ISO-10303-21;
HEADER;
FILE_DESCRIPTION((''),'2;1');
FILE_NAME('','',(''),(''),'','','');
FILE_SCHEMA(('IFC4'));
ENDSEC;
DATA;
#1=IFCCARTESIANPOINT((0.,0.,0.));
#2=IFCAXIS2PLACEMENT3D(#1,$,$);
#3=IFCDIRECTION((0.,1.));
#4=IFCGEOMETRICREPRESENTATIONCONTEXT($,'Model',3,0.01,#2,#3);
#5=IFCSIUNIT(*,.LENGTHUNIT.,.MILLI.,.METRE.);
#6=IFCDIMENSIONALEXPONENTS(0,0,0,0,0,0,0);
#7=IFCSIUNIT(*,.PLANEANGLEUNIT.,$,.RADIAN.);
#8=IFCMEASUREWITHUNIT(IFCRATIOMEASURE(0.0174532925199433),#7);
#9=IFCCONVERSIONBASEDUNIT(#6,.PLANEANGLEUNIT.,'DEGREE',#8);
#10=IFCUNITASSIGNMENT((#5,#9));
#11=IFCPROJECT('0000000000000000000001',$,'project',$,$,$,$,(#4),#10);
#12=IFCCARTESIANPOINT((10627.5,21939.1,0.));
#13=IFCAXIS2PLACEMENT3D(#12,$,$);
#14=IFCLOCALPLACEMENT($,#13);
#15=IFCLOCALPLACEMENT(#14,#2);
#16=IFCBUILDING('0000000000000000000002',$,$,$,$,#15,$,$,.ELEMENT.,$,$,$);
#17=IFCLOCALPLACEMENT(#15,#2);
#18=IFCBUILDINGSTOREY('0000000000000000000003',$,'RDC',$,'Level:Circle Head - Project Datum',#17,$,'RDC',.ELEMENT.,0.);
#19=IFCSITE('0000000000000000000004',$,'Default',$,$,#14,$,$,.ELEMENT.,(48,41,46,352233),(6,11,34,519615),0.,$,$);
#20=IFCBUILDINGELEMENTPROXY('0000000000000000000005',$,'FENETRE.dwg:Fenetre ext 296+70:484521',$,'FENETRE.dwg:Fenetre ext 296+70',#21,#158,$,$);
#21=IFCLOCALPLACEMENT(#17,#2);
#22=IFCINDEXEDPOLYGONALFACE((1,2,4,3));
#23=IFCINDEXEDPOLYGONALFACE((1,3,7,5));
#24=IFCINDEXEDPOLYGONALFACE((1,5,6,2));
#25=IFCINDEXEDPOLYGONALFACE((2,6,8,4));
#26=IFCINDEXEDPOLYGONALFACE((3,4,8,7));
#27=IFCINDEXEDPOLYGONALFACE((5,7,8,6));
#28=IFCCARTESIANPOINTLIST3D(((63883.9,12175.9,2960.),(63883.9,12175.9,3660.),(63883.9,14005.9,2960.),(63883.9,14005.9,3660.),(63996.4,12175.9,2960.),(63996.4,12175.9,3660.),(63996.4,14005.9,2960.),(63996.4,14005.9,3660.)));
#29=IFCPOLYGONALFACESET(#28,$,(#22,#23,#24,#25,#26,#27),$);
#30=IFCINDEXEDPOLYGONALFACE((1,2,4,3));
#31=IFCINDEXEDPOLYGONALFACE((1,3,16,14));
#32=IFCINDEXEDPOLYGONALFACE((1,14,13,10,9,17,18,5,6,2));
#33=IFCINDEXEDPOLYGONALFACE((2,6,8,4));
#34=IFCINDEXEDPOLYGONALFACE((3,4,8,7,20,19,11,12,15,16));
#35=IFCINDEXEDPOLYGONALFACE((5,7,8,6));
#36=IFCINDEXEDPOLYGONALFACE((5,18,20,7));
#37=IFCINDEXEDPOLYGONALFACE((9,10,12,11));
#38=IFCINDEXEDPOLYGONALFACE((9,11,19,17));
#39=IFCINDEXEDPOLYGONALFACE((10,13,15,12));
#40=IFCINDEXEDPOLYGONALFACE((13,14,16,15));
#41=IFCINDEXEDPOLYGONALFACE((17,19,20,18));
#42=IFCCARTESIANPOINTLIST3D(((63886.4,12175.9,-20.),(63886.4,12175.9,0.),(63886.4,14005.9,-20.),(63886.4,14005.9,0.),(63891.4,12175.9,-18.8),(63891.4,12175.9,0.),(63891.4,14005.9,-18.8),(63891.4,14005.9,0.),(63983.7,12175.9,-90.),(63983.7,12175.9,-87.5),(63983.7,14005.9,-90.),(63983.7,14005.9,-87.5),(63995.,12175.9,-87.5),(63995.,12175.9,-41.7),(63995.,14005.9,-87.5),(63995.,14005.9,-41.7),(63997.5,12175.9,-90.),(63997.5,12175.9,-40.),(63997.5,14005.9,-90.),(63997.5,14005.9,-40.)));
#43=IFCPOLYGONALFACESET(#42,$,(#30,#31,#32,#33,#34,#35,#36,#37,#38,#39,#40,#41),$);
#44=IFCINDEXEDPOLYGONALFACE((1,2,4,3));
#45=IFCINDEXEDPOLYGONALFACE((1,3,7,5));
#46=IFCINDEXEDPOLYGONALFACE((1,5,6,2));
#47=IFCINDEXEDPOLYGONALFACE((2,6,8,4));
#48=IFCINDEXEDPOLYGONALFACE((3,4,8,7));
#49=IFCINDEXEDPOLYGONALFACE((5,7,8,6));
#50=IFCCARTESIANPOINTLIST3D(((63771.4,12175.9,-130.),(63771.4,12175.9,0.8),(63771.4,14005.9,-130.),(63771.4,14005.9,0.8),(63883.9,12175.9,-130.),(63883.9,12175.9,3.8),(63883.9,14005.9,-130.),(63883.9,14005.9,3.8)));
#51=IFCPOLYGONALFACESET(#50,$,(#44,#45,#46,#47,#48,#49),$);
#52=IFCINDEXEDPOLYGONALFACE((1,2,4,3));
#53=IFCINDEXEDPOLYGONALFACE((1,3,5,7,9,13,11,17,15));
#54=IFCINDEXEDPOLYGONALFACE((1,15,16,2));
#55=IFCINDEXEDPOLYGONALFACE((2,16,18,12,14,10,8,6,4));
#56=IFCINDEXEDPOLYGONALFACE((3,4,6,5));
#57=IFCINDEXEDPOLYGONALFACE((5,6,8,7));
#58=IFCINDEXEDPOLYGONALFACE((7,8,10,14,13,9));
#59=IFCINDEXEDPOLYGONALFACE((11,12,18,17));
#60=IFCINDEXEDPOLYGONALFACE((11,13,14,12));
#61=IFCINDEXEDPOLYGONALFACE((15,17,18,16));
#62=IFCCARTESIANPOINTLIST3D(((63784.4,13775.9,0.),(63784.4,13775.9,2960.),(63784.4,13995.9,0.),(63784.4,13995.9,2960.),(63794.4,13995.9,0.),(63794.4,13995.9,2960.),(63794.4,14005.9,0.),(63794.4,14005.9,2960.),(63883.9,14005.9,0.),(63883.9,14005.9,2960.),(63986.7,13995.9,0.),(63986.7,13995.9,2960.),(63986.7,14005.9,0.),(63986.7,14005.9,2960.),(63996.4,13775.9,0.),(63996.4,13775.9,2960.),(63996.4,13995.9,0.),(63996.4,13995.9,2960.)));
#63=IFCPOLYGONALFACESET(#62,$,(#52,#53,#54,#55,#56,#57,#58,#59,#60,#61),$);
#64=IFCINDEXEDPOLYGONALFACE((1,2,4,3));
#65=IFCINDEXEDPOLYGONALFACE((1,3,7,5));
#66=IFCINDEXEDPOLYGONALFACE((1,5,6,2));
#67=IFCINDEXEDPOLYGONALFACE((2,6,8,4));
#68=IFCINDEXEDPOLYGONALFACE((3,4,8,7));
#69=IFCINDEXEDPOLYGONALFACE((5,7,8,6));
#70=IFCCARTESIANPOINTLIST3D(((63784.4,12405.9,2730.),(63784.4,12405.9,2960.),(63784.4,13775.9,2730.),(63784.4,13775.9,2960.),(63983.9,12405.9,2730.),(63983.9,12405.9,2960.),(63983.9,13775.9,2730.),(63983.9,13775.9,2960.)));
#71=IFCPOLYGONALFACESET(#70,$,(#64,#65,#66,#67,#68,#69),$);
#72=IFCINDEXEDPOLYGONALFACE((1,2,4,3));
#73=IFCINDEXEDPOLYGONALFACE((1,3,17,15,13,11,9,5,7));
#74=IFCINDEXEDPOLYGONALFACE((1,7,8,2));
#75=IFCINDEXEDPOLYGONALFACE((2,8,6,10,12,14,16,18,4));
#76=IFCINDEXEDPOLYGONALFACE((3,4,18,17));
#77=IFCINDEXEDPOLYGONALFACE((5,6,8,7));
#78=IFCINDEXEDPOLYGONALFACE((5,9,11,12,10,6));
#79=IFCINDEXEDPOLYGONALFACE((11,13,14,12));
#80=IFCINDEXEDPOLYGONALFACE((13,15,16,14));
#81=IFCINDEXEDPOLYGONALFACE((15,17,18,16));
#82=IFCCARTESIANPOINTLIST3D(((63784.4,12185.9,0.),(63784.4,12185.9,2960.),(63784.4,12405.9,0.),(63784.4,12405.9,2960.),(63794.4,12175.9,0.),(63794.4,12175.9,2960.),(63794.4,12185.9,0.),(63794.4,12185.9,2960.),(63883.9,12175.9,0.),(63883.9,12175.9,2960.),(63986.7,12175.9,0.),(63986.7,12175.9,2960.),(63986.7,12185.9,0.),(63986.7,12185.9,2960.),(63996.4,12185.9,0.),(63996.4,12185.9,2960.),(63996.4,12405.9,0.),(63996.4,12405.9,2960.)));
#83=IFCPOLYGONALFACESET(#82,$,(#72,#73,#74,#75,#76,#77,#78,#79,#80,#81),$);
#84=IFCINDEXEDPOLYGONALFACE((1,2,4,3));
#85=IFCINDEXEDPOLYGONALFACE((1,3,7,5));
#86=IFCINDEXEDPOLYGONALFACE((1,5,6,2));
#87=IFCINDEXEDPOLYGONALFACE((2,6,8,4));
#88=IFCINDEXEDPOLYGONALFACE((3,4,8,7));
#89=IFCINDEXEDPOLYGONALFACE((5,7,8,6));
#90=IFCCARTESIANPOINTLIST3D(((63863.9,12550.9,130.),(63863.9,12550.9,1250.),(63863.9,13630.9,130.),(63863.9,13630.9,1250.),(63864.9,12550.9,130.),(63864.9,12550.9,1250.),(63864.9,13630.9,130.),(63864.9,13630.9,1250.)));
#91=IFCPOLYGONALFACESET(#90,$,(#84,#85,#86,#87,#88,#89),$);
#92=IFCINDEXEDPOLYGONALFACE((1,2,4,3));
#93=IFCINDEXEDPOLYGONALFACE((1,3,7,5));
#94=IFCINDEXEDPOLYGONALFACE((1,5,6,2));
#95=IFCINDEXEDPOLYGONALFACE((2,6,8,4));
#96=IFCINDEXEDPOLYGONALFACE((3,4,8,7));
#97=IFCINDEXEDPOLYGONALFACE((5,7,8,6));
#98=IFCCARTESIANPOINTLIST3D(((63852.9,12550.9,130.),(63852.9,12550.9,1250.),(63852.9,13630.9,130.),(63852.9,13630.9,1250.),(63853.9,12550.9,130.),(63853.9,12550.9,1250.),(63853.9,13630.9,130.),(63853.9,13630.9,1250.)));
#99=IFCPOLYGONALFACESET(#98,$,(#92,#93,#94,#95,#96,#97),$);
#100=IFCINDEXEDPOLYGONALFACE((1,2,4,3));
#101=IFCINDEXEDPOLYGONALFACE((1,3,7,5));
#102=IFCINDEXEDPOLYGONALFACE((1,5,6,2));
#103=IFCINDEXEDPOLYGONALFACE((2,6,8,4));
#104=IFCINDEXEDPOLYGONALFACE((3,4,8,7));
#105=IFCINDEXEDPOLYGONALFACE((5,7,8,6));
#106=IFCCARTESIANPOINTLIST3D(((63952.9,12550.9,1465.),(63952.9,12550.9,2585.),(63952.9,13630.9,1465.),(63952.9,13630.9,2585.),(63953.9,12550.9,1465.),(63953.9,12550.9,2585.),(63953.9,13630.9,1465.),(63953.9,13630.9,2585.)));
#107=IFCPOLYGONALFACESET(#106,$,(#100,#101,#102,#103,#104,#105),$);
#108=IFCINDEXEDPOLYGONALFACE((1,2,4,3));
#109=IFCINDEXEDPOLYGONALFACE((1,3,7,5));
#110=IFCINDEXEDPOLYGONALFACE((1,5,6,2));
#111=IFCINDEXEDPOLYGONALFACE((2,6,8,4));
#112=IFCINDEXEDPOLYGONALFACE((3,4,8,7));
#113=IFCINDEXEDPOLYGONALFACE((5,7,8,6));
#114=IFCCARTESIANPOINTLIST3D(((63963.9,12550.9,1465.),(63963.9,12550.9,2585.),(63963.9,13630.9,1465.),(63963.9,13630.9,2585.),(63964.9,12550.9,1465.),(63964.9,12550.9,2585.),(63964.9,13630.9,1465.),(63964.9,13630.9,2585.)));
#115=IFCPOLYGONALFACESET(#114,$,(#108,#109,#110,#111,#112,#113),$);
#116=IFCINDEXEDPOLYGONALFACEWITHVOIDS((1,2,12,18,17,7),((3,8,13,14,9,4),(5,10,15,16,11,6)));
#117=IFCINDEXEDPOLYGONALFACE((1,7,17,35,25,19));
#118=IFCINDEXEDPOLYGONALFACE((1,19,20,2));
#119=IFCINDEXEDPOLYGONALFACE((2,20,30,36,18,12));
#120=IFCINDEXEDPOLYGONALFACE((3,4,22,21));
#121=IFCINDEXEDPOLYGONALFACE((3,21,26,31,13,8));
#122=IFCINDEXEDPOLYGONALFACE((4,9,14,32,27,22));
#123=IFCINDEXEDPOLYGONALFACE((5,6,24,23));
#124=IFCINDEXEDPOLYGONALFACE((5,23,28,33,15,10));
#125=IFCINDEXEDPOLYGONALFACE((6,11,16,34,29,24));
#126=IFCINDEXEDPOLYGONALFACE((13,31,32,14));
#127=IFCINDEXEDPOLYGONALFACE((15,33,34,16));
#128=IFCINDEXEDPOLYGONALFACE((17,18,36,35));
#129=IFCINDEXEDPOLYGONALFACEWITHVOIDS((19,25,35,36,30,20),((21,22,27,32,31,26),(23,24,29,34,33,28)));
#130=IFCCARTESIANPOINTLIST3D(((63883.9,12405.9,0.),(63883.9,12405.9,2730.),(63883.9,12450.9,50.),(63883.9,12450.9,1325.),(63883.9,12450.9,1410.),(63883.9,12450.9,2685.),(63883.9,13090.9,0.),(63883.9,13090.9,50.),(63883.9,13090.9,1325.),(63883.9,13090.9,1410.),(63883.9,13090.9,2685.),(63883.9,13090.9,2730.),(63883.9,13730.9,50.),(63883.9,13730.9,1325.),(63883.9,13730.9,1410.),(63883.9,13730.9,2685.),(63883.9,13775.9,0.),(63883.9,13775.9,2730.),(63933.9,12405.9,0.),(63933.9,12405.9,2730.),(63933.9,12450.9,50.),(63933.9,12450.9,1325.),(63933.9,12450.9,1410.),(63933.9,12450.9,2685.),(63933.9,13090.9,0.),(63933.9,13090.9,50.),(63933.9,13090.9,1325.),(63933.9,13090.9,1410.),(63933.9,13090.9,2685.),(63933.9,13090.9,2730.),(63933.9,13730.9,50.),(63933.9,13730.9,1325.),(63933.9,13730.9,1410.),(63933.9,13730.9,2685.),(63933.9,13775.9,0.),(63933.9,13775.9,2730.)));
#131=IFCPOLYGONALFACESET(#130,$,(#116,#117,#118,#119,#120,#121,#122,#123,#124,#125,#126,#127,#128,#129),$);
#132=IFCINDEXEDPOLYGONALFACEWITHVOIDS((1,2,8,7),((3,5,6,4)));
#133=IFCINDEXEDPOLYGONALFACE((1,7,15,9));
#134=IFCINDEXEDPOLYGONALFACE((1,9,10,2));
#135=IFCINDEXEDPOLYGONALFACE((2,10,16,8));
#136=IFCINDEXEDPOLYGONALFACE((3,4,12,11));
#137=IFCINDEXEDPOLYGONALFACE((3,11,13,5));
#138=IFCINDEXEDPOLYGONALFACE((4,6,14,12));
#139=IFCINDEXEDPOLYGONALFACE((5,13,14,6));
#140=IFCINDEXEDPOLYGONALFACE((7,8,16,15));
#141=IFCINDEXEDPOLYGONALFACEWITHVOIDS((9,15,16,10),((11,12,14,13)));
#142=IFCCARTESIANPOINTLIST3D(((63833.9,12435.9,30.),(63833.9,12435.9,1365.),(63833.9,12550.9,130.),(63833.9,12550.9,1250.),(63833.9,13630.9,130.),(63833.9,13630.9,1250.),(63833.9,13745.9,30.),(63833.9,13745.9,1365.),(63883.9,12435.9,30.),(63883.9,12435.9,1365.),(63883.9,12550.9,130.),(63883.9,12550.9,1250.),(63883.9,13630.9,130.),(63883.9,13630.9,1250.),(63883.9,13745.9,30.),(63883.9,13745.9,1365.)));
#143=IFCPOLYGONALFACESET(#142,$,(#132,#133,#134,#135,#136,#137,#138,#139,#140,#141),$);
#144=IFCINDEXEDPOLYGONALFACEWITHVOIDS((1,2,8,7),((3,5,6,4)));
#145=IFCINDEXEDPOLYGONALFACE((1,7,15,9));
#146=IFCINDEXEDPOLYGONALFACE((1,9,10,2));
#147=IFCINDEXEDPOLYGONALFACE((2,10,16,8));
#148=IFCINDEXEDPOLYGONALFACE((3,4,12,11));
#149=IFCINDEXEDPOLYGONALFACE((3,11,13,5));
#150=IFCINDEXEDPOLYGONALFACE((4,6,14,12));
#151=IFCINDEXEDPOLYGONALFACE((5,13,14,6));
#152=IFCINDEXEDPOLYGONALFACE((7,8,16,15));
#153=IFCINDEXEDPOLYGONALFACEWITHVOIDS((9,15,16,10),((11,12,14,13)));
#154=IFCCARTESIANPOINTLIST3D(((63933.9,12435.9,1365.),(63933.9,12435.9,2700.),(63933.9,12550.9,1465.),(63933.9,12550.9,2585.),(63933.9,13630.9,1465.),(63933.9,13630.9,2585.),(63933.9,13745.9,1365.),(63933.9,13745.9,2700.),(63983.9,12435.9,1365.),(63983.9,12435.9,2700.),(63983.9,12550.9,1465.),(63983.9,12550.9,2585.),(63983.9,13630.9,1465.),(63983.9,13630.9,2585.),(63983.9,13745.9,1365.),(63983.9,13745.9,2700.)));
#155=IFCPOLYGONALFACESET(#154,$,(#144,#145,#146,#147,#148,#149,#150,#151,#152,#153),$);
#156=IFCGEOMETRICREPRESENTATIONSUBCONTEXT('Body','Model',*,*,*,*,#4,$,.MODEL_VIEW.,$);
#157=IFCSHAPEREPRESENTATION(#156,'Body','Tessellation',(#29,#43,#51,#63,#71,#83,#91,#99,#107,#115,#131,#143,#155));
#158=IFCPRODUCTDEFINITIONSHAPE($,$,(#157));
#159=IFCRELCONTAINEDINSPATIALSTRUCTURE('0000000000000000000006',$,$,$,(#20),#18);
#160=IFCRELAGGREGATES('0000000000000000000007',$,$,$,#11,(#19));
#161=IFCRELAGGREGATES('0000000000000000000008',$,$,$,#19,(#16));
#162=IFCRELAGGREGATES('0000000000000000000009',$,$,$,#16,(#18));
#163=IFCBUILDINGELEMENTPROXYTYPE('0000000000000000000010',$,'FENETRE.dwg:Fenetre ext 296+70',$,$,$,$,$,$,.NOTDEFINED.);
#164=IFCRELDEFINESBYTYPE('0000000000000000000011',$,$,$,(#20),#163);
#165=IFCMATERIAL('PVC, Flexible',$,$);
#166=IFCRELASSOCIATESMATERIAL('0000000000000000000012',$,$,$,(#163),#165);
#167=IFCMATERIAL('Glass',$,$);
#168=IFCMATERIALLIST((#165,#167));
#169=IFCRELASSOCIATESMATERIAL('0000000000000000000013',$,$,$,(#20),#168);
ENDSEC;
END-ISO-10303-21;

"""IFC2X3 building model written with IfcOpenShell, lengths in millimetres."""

from ifc_helpers import new_model, entity, si_unit, converted_unit, direction, frame, frame_2d, origin, origin_2d_with_axis, place, context, subcontext, project, spatial, polyline, rectangle, outline, extrude, source, transform, mapped, material, material_list, type_object, type_shapes, element, save


model = new_model("IFC2X3")

# Units and contexts
model_context = context("Model", 3, precision=0.01, world=origin(), true_north=direction((0.0, 1.0)))
body_context = subcontext(model_context, "Body", "Model", "MODEL_VIEW")
ifc_project = project(units=[si_unit("LENGTHUNIT", "METRE", prefix="MILLI"), converted_unit("PLANEANGLEUNIT", "DEGREE", entity("IfcRatioMeasure", 0.0174532925199433), si_unit("PLANEANGLEUNIT", "RADIAN"), dimensions=[0, 0, 0, 0, 0, 0, 0])], contexts=[model_context])

# Site, building, storey
site_placement = place(None, frame((10627.5, 21939.1, 0.0)))
site = spatial("IfcSite", under=ifc_project, at=site_placement, Name="Default", CompositionType="ELEMENT", RefLatitude=(48, 41, 46, 352233), RefLongitude=(6, 11, 34, 519615), RefElevation=0.0)
building_placement = place(site_placement, origin())
building = spatial("IfcBuilding", under=site, at=building_placement, CompositionType="ELEMENT")
storey_placement = place(building_placement, origin())
storey = spatial("IfcBuildingStorey", under=building, at=storey_placement, Name="RDC", ObjectType="Level:Circle Head - Project Datum", LongName="RDC", CompositionType="ELEMENT", Elevation=0.0)

# Building element proxy
ifc_material_1 = material(Name="PVC, Flexible")
ifc_material_2 = material(Name="Glass")
building_element_proxy_type_1 = type_object("IfcBuildingElementProxyType", Name="FENETRE.dwg:Fenetre ext 296+70", PredefinedType="NOTDEFINED", material=ifc_material_1)
shared_shape_1 = source(origin(), body_context, "Body", "SweptSolid", [
    extrude(rectangle(XDim=112.5, YDim=1830.0, at=origin_2d_with_axis()), frame((-10.4, -56.3, 2960.0), z_axis=(0.0, 0.0, 1.0), x_axis=(0.0, 1.0, 0.0)), (0.0, 0.0, 1.0), 700.0),
    extrude(outline(polyline([(27.5, -64.4), (47.5, -64.4), (47.5, -59.4), (28.8, -59.4), (7.5, 46.7), (-42.5, 46.7), (-42.5, 32.9), (-40.0, 32.9), (-40.0, 44.2), (5.8, 44.2), (27.5, -64.4)])), frame((-925.4, -66.9, -47.5), z_axis=(1.0, 0.0, 0.0), x_axis=(0.0, 0.0, 1.0)), (0.0, 0.0, 1.0), 1830.0),
    extrude(outline(polyline([(-54.5, -66.1), (58.0, -66.1), (54.5, 67.6), (-58.0, 64.6), (-54.5, -66.1)])), frame((-925.4, 56.3, -63.8), z_axis=(1.0, 0.0, 0.0), x_axis=(0.0, -0.999645, 0.02665)), (0.0, 0.0, 1.0), 1830.0),
    extrude(outline(polyline([(-97.0, -55.6), (5.9, -55.6), (95.4, -55.6), (95.4, -45.6), (105.4, -45.6), (105.4, 174.4), (-106.6, 174.4), (-106.6, -45.6), (-97.0, -45.6), (-97.0, -55.6)])), frame((849.0, -5.9, 0.0), z_axis=(0.0, 0.0, 1.0), x_axis=(0.0, 1.0, 0.0)), (0.0, 0.0, 1.0), 2960.0),
    extrude(rectangle(XDim=1370.0, YDim=199.5, at=origin_2d_with_axis()), frame((-10.4, -0.3, 2730.0), z_axis=(0.0, 0.0, 1.0), x_axis=(-1.0, 0.0, 0.0)), (0.0, 0.0, 1.0), 230.0),
    extrude(outline(polyline([(-55.6, 97.0), (-55.6, -5.9), (-55.6, -95.4), (-45.6, -95.4), (-45.6, -105.4), (174.4, -105.4), (174.4, 106.6), (-45.6, 106.6), (-45.6, 97.0), (-55.6, 97.0)])), frame((-869.9, -5.9, 0.0), z_axis=(0.0, 0.0, -1.0), x_axis=(1.0, 0.0, 0.0)), (0.0, 0.0, -1.0), 2960.0),
    extrude(rectangle(XDim=1080.0, YDim=1.0, at=origin_2d_with_axis()), frame((-10.4, 19.5, 130.0), z_axis=(0.0, 0.0, 1.0), x_axis=(-1.0, 0.0, 0.0)), (0.0, 0.0, 1.0), 1120.0),
    extrude(rectangle(XDim=1080.0, YDim=1.0, at=origin_2d_with_axis()), frame((-10.4, 30.5, 130.0), z_axis=(0.0, 0.0, 1.0), x_axis=(-1.0, 0.0, 0.0)), (0.0, 0.0, 1.0), 1120.0),
    extrude(rectangle(XDim=1080.0, YDim=1.0, at=frame_2d((0.0, 0.0), x_axis=(1.0, 0.0))), frame((-10.4, -69.5, 1465.0), z_axis=(0.0, 0.0, 1.0), x_axis=(-1.0, 0.0, 0.0)), (0.0, 0.0, 1.0), 1120.0),
    extrude(rectangle(XDim=1080.0, YDim=1.0, at=frame_2d((0.0, 0.0), x_axis=(1.0, 0.0))), frame((-10.4, -80.5, 1465.0), z_axis=(0.0, 0.0, 1.0), x_axis=(-1.0, 0.0, 0.0)), (0.0, 0.0, 1.0), 1120.0),
    extrude(outline(polyline([(-685.0, -1365.0), (0.0, -1365.0), (685.0, -1365.0), (685.0, 1365.0), (0.0, 1365.0), (-685.0, 1365.0), (-685.0, -1365.0)]), holes=[polyline([(-640.0, -1320.0), (-640.0, -45.0), (0.0, -45.0), (640.0, -45.0), (640.0, -1320.0), (0.0, -1320.0), (-640.0, -1320.0)]), polyline([(-640.0, 40.0), (-640.0, 1315.0), (0.0, 1315.0), (640.0, 1315.0), (640.0, 40.0), (0.0, 40.0), (-640.0, 40.0)])]), frame((-10.4, -50.0, 1365.0), z_axis=(0.0, 1.0, 0.0), x_axis=(1.0, 0.0, 0.0)), (0.0, 0.0, 1.0), 50.0),
    extrude(outline(polyline([(-655.0, -667.5), (655.0, -667.5), (655.0, 667.5), (-655.0, 667.5), (-655.0, -667.5)]), holes=[polyline([(-540.0, 552.5), (540.0, 552.5), (540.0, -567.5), (-540.0, -567.5), (-540.0, 552.5)])]), frame((-10.4, 0.0, 697.5), z_axis=(0.0, 1.0, 0.0), x_axis=(-1.0, 0.0, 0.0)), (0.0, 0.0, 1.0), 50.0),
    extrude(outline(polyline([(-655.0, -667.5), (655.0, -667.5), (655.0, 667.5), (-655.0, 667.5), (-655.0, -667.5)]), holes=[polyline([(-540.0, 552.5), (540.0, 552.5), (540.0, -567.5), (-540.0, -567.5), (-540.0, 552.5)])]), frame((-10.4, -100.0, 2032.5), z_axis=(0.0, 1.0, 0.0), x_axis=(-1.0, 0.0, 0.0)), (0.0, 0.0, 1.0), 50.0),
])
type_shapes(building_element_proxy_type_1, [shared_shape_1])
ifc_material_list_1 = material_list([ifc_material_1, ifc_material_2])
proxy_1_placement = place(storey_placement, frame((63883.9, 13101.3, 0.0), z_axis=(0.0, 0.0, 1.0), x_axis=(0.0, 1.0, 0.0)))
element("IfcBuildingElementProxy", 1, at=proxy_1_placement, inside=storey, type_object=building_element_proxy_type_1, material=ifc_material_list_1, Name="FENETRE.dwg:Fenetre ext 296+70:484521", ObjectType="FENETRE.dwg:Fenetre ext 296+70", context=body_context, shape_type="MappedRepresentation", body=[
    mapped(shared_shape_1, transform((0.0, 0.0, 0.0), scale=1.0)),
])

save(model, "model.ifc")
